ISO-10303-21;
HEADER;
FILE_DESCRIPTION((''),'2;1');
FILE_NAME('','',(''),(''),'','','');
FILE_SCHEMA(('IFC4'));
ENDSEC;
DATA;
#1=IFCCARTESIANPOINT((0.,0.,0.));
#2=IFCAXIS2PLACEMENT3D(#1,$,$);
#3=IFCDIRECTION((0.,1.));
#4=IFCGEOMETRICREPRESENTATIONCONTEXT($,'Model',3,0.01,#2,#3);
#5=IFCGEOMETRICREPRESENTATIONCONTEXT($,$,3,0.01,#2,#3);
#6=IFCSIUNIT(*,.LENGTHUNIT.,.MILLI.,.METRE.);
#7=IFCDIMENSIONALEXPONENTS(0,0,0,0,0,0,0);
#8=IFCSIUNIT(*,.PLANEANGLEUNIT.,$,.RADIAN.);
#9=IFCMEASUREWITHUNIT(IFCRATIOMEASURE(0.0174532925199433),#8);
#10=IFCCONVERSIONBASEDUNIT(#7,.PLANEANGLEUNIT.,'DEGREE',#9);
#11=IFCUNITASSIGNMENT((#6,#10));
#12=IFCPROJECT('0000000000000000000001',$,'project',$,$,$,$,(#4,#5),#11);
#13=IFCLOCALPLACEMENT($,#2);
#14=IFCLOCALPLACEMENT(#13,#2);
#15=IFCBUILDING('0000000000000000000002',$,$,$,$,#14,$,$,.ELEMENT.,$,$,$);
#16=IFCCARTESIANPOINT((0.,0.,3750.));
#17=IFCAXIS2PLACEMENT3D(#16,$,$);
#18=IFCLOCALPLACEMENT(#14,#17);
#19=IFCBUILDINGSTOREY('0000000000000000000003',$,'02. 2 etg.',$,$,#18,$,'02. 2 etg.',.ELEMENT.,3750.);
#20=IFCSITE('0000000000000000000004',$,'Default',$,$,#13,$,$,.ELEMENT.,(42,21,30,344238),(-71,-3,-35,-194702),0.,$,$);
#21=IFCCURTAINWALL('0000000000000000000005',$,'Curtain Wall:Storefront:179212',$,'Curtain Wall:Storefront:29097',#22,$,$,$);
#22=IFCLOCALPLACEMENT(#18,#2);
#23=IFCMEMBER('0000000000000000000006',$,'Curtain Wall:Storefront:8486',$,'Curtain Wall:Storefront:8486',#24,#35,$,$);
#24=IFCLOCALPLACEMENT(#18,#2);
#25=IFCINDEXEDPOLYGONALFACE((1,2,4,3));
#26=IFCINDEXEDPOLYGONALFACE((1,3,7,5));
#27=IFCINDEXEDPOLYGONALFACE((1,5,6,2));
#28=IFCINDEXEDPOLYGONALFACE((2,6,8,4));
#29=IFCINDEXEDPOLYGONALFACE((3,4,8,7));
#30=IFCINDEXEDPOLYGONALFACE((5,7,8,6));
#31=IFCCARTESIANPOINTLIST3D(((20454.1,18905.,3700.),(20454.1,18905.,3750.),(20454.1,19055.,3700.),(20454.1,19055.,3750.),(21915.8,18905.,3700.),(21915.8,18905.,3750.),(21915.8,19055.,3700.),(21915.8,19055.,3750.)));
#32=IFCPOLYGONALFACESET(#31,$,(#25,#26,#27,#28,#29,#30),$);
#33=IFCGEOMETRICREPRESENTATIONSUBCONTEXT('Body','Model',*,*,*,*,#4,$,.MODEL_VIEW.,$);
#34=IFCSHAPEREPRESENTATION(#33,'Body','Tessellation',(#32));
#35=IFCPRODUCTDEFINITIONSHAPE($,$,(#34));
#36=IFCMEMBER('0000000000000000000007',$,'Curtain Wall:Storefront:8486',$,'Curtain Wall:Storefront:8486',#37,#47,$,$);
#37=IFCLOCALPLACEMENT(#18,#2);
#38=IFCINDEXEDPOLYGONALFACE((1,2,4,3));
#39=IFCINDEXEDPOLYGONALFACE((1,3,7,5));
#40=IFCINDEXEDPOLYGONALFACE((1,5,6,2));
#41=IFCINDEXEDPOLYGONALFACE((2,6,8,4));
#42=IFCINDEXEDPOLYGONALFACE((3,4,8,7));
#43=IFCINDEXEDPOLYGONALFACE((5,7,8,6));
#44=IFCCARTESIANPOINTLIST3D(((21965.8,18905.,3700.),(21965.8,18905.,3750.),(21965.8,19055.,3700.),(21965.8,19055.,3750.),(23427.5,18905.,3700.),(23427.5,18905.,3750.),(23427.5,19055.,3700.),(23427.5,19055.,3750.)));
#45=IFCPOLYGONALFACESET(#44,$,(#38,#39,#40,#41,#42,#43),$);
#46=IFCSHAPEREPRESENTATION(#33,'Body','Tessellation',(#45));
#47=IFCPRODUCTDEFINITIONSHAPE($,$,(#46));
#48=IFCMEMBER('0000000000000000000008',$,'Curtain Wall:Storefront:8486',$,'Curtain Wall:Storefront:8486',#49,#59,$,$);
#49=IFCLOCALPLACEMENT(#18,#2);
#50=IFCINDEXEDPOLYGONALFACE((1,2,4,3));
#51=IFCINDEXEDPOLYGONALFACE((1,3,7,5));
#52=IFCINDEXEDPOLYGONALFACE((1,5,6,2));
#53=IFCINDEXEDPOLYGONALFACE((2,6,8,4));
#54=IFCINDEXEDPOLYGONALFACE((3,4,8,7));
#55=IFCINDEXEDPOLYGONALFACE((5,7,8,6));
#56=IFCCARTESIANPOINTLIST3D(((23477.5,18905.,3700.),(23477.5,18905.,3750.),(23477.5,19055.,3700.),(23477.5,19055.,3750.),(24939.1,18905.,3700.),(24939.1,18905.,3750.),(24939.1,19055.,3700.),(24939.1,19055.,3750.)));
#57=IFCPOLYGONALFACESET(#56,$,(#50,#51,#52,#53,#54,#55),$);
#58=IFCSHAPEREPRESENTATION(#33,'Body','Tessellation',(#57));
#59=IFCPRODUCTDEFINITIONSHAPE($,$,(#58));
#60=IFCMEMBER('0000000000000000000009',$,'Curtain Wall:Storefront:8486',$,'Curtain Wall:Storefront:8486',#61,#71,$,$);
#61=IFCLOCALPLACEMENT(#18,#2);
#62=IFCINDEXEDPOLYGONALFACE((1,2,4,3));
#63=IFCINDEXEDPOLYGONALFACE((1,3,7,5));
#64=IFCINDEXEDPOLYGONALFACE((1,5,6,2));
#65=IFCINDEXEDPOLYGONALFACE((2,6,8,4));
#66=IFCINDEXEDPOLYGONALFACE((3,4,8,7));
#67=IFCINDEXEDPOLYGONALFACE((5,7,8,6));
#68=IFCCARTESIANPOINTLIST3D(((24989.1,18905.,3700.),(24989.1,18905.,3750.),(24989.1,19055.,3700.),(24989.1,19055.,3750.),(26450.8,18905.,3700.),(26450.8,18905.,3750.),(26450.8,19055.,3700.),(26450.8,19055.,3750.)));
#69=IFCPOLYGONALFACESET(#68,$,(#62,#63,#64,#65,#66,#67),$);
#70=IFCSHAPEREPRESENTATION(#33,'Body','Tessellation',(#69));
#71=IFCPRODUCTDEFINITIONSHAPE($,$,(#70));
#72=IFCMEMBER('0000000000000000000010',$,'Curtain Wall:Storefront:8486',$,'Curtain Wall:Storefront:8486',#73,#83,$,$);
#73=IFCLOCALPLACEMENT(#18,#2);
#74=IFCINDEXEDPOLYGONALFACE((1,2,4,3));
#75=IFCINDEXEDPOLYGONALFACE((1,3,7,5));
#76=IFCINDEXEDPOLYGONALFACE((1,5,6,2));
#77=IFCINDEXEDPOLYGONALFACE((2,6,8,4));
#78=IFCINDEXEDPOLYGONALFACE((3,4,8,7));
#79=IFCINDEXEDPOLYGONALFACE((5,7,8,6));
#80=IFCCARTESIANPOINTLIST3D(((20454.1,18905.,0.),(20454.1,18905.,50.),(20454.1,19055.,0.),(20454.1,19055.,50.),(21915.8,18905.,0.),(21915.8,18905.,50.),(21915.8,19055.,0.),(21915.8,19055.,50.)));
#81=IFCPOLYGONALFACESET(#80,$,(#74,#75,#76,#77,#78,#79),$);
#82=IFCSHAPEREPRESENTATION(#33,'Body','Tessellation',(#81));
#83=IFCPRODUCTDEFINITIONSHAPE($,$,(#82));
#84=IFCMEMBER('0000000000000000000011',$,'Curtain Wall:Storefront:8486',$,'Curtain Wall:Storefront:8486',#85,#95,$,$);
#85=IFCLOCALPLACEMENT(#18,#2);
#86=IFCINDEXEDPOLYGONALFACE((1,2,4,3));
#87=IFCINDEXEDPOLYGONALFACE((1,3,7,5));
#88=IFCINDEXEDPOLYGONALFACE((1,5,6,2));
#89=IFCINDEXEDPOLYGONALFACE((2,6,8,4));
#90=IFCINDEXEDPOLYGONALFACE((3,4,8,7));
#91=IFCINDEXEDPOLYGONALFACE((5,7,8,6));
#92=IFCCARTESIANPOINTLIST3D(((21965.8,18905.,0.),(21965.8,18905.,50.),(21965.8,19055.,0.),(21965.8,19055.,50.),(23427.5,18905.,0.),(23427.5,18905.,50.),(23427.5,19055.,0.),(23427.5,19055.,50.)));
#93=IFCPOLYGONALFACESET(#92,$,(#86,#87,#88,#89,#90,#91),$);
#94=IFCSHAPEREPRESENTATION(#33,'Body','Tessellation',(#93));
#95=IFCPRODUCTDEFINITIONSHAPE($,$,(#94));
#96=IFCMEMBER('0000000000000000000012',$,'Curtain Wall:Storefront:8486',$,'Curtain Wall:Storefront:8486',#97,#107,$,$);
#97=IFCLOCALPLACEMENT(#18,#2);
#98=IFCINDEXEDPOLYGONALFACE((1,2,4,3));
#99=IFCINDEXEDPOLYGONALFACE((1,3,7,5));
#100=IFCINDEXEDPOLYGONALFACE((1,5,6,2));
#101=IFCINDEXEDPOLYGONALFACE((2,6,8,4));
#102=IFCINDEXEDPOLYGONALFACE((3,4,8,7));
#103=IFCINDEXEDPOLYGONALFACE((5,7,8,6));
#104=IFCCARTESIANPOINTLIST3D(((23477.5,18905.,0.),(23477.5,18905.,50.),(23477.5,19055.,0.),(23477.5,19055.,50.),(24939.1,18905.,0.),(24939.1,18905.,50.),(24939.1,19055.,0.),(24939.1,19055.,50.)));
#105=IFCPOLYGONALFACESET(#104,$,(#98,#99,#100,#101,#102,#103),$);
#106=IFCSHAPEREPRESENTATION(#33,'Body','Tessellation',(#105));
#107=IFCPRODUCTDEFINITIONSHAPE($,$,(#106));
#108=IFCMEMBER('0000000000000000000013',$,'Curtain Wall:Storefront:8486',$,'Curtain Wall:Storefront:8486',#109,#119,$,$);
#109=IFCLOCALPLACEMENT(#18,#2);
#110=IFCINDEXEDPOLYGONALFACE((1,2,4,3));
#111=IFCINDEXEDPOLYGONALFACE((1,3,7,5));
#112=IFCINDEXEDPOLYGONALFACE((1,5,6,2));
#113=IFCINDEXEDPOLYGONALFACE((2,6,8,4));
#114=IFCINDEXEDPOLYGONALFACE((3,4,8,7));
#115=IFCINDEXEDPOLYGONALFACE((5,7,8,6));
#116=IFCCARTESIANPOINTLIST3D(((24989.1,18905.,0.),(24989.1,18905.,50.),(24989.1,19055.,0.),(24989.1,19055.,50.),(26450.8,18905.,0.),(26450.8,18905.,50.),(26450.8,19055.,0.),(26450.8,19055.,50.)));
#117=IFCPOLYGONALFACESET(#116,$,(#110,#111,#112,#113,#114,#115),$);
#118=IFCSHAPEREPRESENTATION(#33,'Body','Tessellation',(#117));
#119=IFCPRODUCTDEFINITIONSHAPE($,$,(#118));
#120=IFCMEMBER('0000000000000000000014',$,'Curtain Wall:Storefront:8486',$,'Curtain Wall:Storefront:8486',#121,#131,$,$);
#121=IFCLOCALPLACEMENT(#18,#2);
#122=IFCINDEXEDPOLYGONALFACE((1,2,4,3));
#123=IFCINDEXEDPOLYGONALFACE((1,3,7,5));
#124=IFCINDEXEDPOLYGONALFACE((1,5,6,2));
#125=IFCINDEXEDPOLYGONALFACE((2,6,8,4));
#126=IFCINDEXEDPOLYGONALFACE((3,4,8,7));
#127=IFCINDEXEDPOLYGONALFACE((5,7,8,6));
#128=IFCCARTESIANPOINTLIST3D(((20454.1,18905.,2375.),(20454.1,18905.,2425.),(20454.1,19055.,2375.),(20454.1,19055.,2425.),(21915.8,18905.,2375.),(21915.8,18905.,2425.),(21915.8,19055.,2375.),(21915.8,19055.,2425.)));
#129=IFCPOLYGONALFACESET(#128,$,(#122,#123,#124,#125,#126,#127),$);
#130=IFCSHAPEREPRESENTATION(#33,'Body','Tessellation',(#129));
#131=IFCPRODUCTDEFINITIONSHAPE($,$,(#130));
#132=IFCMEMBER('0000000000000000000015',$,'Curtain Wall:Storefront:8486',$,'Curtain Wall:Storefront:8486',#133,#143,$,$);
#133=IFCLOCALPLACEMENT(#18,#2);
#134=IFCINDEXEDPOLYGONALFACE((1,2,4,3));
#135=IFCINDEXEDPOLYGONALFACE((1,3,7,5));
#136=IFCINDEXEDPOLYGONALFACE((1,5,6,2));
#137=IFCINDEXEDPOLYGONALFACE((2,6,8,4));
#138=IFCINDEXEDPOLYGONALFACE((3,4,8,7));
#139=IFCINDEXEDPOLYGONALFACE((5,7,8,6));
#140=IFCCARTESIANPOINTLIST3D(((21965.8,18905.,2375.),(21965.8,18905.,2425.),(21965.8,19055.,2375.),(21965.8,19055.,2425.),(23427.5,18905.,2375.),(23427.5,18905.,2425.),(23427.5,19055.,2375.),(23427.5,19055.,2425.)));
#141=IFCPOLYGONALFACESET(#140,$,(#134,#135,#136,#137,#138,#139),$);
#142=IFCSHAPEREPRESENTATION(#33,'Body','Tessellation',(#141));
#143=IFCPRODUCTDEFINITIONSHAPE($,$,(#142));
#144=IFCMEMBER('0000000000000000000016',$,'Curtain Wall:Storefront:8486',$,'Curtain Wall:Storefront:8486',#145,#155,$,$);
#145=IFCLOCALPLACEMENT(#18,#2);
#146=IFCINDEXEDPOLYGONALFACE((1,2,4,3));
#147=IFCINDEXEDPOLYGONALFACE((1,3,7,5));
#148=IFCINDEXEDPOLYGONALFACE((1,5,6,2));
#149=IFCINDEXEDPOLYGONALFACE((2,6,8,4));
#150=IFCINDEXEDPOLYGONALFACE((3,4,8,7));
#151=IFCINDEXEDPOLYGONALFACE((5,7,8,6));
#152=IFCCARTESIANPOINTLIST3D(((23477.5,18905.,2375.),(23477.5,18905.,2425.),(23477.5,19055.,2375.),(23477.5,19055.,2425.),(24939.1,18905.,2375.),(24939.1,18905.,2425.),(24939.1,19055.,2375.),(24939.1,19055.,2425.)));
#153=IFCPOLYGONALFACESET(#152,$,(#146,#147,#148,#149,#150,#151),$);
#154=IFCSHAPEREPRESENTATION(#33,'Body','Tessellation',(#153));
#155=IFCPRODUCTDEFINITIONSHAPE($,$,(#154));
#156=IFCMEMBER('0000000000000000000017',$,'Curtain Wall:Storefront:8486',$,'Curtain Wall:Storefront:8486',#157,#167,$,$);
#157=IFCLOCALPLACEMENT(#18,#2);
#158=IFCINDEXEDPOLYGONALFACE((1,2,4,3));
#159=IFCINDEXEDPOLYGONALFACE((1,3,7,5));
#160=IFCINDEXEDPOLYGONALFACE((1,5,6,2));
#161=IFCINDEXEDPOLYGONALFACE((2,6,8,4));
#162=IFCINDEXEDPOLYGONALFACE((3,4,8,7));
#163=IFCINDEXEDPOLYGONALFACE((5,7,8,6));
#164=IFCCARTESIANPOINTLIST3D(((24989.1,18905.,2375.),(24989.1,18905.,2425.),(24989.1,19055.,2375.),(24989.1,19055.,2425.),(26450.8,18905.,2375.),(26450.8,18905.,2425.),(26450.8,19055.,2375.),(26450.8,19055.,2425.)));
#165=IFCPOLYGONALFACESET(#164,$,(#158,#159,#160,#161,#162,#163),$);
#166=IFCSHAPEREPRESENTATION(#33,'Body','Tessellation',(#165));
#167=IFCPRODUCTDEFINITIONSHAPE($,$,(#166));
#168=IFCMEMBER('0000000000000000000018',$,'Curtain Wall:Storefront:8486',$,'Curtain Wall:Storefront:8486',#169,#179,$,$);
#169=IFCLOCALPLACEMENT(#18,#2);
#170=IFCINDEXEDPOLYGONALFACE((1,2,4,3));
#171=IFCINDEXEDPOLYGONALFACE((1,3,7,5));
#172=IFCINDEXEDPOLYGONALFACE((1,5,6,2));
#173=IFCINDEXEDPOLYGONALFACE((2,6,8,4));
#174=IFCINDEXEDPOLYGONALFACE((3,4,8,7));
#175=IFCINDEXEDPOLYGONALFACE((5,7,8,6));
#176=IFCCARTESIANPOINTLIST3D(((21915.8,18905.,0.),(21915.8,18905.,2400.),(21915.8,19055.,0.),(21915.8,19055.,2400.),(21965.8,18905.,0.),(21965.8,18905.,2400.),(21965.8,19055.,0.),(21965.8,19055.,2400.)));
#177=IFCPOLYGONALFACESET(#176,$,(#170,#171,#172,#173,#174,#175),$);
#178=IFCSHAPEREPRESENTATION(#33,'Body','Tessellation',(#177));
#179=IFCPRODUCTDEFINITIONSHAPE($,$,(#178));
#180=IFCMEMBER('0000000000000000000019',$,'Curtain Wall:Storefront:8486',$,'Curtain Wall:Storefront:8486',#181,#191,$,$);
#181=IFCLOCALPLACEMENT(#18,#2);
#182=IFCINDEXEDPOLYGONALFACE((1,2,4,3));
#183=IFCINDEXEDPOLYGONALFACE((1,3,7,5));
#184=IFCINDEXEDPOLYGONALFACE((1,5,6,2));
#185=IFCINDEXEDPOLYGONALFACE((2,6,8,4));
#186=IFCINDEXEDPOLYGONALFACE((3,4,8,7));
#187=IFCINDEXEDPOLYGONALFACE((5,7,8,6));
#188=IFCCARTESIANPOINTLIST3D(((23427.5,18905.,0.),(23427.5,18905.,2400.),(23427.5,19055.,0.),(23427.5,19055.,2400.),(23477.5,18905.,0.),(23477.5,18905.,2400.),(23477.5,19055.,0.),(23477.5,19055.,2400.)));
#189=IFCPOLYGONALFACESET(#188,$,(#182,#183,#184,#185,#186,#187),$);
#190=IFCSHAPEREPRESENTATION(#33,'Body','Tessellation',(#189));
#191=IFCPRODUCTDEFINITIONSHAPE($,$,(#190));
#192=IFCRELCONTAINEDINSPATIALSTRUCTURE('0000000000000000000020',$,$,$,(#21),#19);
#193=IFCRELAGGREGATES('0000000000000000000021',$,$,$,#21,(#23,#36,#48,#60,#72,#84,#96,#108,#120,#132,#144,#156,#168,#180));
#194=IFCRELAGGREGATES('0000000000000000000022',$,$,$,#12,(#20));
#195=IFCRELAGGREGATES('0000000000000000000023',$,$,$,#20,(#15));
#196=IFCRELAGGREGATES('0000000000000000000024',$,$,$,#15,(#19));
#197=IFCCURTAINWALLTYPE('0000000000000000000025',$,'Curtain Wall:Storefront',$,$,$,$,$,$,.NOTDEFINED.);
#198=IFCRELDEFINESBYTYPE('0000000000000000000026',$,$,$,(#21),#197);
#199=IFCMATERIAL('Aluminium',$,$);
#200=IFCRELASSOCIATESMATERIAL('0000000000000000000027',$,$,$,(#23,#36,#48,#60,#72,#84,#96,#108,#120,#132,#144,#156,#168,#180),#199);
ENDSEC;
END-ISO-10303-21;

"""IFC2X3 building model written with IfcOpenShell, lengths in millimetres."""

from ifc_helpers import new_model, entity, si_unit, converted_unit, direction, frame, frame_2d, origin, origin_2d_with_axis, place, context, subcontext, project, spatial, rectangle, extrude, material, type_object, element, aggregate, save


model = new_model("IFC2X3")

# Units and contexts
model_context = context("Model", 3, precision=0.01, world=origin(), true_north=direction((0.0, 1.0)))
context_of_model = context(None, 3, precision=0.01, world=origin(), true_north=direction((0.0, 1.0)))
body_context = subcontext(model_context, "Body", "Model", "MODEL_VIEW")
ifc_project = project(units=[si_unit("LENGTHUNIT", "METRE", prefix="MILLI"), converted_unit("PLANEANGLEUNIT", "DEGREE", entity("IfcRatioMeasure", 0.0174532925199433), si_unit("PLANEANGLEUNIT", "RADIAN"), dimensions=[0, 0, 0, 0, 0, 0, 0])], contexts=[model_context, context_of_model])

# Site, building, storey
site_placement = place(None, origin())
site = spatial("IfcSite", under=ifc_project, at=site_placement, Name="Default", CompositionType="ELEMENT", RefLatitude=(42, 21, 30, 344238), RefLongitude=(-71, -3, -35, -194702), RefElevation=0.0)
building_placement = place(site_placement, origin())
building = spatial("IfcBuilding", under=site, at=building_placement, CompositionType="ELEMENT")
storey_placement = place(building_placement, frame((0.0, 0.0, 3750.0)))
storey = spatial("IfcBuildingStorey", under=building, at=storey_placement, Name="02. 2 etg.", LongName="02. 2 etg.", CompositionType="ELEMENT", Elevation=3750.0)

# Curtain wall, members
curtain_wall_type = type_object("IfcCurtainWallType", Name="Curtain Wall:Storefront", PredefinedType="NOTDEFINED")
curtain_wall_placement = place(storey_placement, frame((0.0, 0.0, -3750.0)))
curtain_wall = element("IfcCurtainWall", 1, at=curtain_wall_placement, inside=storey, type_object=curtain_wall_type, Name="Curtain Wall:Storefront:179212", ObjectType="Curtain Wall:Storefront:29097")
ifc_material_1 = material(Name="Aluminium")
member_1_placement = place(curtain_wall_placement, frame((20454.1, 18905.0, 7450.0)))
member_1 = element("IfcMember", 2, at=member_1_placement, material=ifc_material_1, Name="Curtain Wall:Storefront:8486", ObjectType="Curtain Wall:Storefront:8486", context=body_context, shape_type="SweptSolid", body=[
    extrude(rectangle(XDim=1461.7, YDim=150.0, at=frame_2d((0.0, 0.0), x_axis=(1.0, 0.0))), frame((730.8, 75.0, 0.0), z_axis=(0.0, 0.0, 1.0), x_axis=(-1.0, 0.0, 0.0)), (0.0, 0.0, 1.0), 50.0),
])
member_2_placement = place(curtain_wall_placement, frame((21965.8, 18905.0, 7450.0)))
member_2 = element("IfcMember", 3, at=member_2_placement, material=ifc_material_1, Name="Curtain Wall:Storefront:8486", ObjectType="Curtain Wall:Storefront:8486", context=body_context, shape_type="SweptSolid", body=[
    extrude(rectangle(XDim=1461.7, YDim=150.0, at=frame_2d((0.0, 0.0), x_axis=(1.0, 0.0))), frame((730.8, 75.0, 0.0), z_axis=(0.0, 0.0, 1.0), x_axis=(-1.0, 0.0, 0.0)), (0.0, 0.0, 1.0), 50.0),
])
member_3_placement = place(curtain_wall_placement, frame((23477.5, 18905.0, 7450.0)))
member_3 = element("IfcMember", 4, at=member_3_placement, material=ifc_material_1, Name="Curtain Wall:Storefront:8486", ObjectType="Curtain Wall:Storefront:8486", context=body_context, shape_type="SweptSolid", body=[
    extrude(rectangle(XDim=1461.7, YDim=150.0, at=origin_2d_with_axis()), frame((730.8, 75.0, 0.0), z_axis=(0.0, 0.0, 1.0), x_axis=(-1.0, 0.0, 0.0)), (0.0, 0.0, 1.0), 50.0),
])
member_4_placement = place(curtain_wall_placement, frame((24989.1, 18905.0, 7450.0)))
member_4 = element("IfcMember", 5, at=member_4_placement, material=ifc_material_1, Name="Curtain Wall:Storefront:8486", ObjectType="Curtain Wall:Storefront:8486", context=body_context, shape_type="SweptSolid", body=[
    extrude(rectangle(XDim=1461.7, YDim=150.0, at=origin_2d_with_axis()), frame((730.8, 75.0, 0.0), z_axis=(0.0, 0.0, 1.0), x_axis=(-1.0, 0.0, 0.0)), (0.0, 0.0, 1.0), 50.0),
])
member_5_placement = place(curtain_wall_placement, frame((20454.1, 18905.0, 3750.0)))
member_5 = element("IfcMember", 6, at=member_5_placement, material=ifc_material_1, Name="Curtain Wall:Storefront:8486", ObjectType="Curtain Wall:Storefront:8486", context=body_context, shape_type="SweptSolid", body=[
    extrude(rectangle(XDim=1461.7, YDim=150.0, at=origin_2d_with_axis()), frame((730.8, 75.0, 0.0)), (0.0, 0.0, 1.0), 50.0),
])
member_6_placement = place(curtain_wall_placement, frame((21965.8, 18905.0, 3750.0)))
member_6 = element("IfcMember", 7, at=member_6_placement, material=ifc_material_1, Name="Curtain Wall:Storefront:8486", ObjectType="Curtain Wall:Storefront:8486", context=body_context, shape_type="SweptSolid", body=[
    extrude(rectangle(XDim=1461.7, YDim=150.0, at=frame_2d((0.0, 0.0), x_axis=(1.0, 0.0))), frame((730.8, 75.0, 0.0)), (0.0, 0.0, 1.0), 50.0),
])
member_7_placement = place(curtain_wall_placement, frame((23477.5, 18905.0, 3750.0)))
member_7 = element("IfcMember", 8, at=member_7_placement, material=ifc_material_1, Name="Curtain Wall:Storefront:8486", ObjectType="Curtain Wall:Storefront:8486", context=body_context, shape_type="SweptSolid", body=[
    extrude(rectangle(XDim=1461.7, YDim=150.0, at=origin_2d_with_axis()), frame((730.8, 75.0, 0.0)), (0.0, 0.0, 1.0), 50.0),
])
member_8_placement = place(curtain_wall_placement, frame((24989.1, 18905.0, 3750.0)))
member_8 = element("IfcMember", 9, at=member_8_placement, material=ifc_material_1, Name="Curtain Wall:Storefront:8486", ObjectType="Curtain Wall:Storefront:8486", context=body_context, shape_type="SweptSolid", body=[
    extrude(rectangle(XDim=1461.7, YDim=150.0, at=origin_2d_with_axis()), frame((730.8, 75.0, 0.0)), (0.0, 0.0, 1.0), 50.0),
])
member_9_placement = place(curtain_wall_placement, frame((20454.1, 18905.0, 6125.0)))
member_9 = element("IfcMember", 10, at=member_9_placement, material=ifc_material_1, Name="Curtain Wall:Storefront:8486", ObjectType="Curtain Wall:Storefront:8486", context=body_context, shape_type="SweptSolid", body=[
    extrude(rectangle(XDim=1461.7, YDim=150.0, at=frame_2d((0.0, 0.0), x_axis=(1.0, 0.0))), frame((730.8, 75.0, 0.0), z_axis=(0.0, 0.0, 1.0), x_axis=(-1.0, 0.0, 0.0)), (0.0, 0.0, 1.0), 50.0),
])
member_10_placement = place(curtain_wall_placement, frame((21965.8, 18905.0, 6125.0)))
member_10 = element("IfcMember", 11, at=member_10_placement, material=ifc_material_1, Name="Curtain Wall:Storefront:8486", ObjectType="Curtain Wall:Storefront:8486", context=body_context, shape_type="SweptSolid", body=[
    extrude(rectangle(XDim=1461.7, YDim=150.0, at=frame_2d((0.0, 0.0), x_axis=(1.0, 0.0))), frame((730.8, 75.0, 0.0), z_axis=(0.0, 0.0, 1.0), x_axis=(-1.0, 0.0, 0.0)), (0.0, 0.0, 1.0), 50.0),
])
member_11_placement = place(curtain_wall_placement, frame((23477.5, 18905.0, 6125.0)))
member_11 = element("IfcMember", 12, at=member_11_placement, material=ifc_material_1, Name="Curtain Wall:Storefront:8486", ObjectType="Curtain Wall:Storefront:8486", context=body_context, shape_type="SweptSolid", body=[
    extrude(rectangle(XDim=1461.7, YDim=150.0, at=frame_2d((0.0, 0.0), x_axis=(1.0, 0.0))), frame((730.8, 75.0, 0.0), z_axis=(0.0, 0.0, 1.0), x_axis=(-1.0, 0.0, 0.0)), (0.0, 0.0, 1.0), 50.0),
])
member_12_placement = place(curtain_wall_placement, frame((24989.1, 18905.0, 6125.0)))
member_12 = element("IfcMember", 13, at=member_12_placement, material=ifc_material_1, Name="Curtain Wall:Storefront:8486", ObjectType="Curtain Wall:Storefront:8486", context=body_context, shape_type="SweptSolid", body=[
    extrude(rectangle(XDim=1461.7, YDim=150.0, at=frame_2d((0.0, 0.0), x_axis=(1.0, 0.0))), frame((730.8, 75.0, 0.0), z_axis=(0.0, 0.0, 1.0), x_axis=(-1.0, 0.0, 0.0)), (0.0, 0.0, 1.0), 50.0),
])
member_13_placement = place(curtain_wall_placement, frame((21915.8, 18905.0, 3750.0)))
member_13 = element("IfcMember", 14, at=member_13_placement, material=ifc_material_1, Name="Curtain Wall:Storefront:8486", ObjectType="Curtain Wall:Storefront:8486", context=body_context, shape_type="SweptSolid", body=[
    extrude(rectangle(XDim=150.0, YDim=50.0, at=frame_2d((0.0, 0.0), x_axis=(1.0, 0.0))), frame((25.0, 75.0, 0.0), z_axis=(0.0, 0.0, 1.0), x_axis=(0.0, 1.0, 0.0)), (0.0, 0.0, 1.0), 2400.0),
])
member_14_placement = place(curtain_wall_placement, frame((23427.5, 18905.0, 3750.0)))
member_14 = element("IfcMember", 15, at=member_14_placement, material=ifc_material_1, Name="Curtain Wall:Storefront:8486", ObjectType="Curtain Wall:Storefront:8486", context=body_context, shape_type="SweptSolid", body=[
    extrude(rectangle(XDim=150.0, YDim=50.0, at=frame_2d((0.0, 0.0), x_axis=(1.0, 0.0))), frame((25.0, 75.0, 0.0), z_axis=(0.0, 0.0, 1.0), x_axis=(0.0, 1.0, 0.0)), (0.0, 0.0, 1.0), 2400.0),
])
aggregate(curtain_wall, [member_1, member_2, member_3, member_4, member_5, member_6, member_7, member_8, member_9, member_10, member_11, member_12, member_13, member_14])

save(model, "model.ifc")
